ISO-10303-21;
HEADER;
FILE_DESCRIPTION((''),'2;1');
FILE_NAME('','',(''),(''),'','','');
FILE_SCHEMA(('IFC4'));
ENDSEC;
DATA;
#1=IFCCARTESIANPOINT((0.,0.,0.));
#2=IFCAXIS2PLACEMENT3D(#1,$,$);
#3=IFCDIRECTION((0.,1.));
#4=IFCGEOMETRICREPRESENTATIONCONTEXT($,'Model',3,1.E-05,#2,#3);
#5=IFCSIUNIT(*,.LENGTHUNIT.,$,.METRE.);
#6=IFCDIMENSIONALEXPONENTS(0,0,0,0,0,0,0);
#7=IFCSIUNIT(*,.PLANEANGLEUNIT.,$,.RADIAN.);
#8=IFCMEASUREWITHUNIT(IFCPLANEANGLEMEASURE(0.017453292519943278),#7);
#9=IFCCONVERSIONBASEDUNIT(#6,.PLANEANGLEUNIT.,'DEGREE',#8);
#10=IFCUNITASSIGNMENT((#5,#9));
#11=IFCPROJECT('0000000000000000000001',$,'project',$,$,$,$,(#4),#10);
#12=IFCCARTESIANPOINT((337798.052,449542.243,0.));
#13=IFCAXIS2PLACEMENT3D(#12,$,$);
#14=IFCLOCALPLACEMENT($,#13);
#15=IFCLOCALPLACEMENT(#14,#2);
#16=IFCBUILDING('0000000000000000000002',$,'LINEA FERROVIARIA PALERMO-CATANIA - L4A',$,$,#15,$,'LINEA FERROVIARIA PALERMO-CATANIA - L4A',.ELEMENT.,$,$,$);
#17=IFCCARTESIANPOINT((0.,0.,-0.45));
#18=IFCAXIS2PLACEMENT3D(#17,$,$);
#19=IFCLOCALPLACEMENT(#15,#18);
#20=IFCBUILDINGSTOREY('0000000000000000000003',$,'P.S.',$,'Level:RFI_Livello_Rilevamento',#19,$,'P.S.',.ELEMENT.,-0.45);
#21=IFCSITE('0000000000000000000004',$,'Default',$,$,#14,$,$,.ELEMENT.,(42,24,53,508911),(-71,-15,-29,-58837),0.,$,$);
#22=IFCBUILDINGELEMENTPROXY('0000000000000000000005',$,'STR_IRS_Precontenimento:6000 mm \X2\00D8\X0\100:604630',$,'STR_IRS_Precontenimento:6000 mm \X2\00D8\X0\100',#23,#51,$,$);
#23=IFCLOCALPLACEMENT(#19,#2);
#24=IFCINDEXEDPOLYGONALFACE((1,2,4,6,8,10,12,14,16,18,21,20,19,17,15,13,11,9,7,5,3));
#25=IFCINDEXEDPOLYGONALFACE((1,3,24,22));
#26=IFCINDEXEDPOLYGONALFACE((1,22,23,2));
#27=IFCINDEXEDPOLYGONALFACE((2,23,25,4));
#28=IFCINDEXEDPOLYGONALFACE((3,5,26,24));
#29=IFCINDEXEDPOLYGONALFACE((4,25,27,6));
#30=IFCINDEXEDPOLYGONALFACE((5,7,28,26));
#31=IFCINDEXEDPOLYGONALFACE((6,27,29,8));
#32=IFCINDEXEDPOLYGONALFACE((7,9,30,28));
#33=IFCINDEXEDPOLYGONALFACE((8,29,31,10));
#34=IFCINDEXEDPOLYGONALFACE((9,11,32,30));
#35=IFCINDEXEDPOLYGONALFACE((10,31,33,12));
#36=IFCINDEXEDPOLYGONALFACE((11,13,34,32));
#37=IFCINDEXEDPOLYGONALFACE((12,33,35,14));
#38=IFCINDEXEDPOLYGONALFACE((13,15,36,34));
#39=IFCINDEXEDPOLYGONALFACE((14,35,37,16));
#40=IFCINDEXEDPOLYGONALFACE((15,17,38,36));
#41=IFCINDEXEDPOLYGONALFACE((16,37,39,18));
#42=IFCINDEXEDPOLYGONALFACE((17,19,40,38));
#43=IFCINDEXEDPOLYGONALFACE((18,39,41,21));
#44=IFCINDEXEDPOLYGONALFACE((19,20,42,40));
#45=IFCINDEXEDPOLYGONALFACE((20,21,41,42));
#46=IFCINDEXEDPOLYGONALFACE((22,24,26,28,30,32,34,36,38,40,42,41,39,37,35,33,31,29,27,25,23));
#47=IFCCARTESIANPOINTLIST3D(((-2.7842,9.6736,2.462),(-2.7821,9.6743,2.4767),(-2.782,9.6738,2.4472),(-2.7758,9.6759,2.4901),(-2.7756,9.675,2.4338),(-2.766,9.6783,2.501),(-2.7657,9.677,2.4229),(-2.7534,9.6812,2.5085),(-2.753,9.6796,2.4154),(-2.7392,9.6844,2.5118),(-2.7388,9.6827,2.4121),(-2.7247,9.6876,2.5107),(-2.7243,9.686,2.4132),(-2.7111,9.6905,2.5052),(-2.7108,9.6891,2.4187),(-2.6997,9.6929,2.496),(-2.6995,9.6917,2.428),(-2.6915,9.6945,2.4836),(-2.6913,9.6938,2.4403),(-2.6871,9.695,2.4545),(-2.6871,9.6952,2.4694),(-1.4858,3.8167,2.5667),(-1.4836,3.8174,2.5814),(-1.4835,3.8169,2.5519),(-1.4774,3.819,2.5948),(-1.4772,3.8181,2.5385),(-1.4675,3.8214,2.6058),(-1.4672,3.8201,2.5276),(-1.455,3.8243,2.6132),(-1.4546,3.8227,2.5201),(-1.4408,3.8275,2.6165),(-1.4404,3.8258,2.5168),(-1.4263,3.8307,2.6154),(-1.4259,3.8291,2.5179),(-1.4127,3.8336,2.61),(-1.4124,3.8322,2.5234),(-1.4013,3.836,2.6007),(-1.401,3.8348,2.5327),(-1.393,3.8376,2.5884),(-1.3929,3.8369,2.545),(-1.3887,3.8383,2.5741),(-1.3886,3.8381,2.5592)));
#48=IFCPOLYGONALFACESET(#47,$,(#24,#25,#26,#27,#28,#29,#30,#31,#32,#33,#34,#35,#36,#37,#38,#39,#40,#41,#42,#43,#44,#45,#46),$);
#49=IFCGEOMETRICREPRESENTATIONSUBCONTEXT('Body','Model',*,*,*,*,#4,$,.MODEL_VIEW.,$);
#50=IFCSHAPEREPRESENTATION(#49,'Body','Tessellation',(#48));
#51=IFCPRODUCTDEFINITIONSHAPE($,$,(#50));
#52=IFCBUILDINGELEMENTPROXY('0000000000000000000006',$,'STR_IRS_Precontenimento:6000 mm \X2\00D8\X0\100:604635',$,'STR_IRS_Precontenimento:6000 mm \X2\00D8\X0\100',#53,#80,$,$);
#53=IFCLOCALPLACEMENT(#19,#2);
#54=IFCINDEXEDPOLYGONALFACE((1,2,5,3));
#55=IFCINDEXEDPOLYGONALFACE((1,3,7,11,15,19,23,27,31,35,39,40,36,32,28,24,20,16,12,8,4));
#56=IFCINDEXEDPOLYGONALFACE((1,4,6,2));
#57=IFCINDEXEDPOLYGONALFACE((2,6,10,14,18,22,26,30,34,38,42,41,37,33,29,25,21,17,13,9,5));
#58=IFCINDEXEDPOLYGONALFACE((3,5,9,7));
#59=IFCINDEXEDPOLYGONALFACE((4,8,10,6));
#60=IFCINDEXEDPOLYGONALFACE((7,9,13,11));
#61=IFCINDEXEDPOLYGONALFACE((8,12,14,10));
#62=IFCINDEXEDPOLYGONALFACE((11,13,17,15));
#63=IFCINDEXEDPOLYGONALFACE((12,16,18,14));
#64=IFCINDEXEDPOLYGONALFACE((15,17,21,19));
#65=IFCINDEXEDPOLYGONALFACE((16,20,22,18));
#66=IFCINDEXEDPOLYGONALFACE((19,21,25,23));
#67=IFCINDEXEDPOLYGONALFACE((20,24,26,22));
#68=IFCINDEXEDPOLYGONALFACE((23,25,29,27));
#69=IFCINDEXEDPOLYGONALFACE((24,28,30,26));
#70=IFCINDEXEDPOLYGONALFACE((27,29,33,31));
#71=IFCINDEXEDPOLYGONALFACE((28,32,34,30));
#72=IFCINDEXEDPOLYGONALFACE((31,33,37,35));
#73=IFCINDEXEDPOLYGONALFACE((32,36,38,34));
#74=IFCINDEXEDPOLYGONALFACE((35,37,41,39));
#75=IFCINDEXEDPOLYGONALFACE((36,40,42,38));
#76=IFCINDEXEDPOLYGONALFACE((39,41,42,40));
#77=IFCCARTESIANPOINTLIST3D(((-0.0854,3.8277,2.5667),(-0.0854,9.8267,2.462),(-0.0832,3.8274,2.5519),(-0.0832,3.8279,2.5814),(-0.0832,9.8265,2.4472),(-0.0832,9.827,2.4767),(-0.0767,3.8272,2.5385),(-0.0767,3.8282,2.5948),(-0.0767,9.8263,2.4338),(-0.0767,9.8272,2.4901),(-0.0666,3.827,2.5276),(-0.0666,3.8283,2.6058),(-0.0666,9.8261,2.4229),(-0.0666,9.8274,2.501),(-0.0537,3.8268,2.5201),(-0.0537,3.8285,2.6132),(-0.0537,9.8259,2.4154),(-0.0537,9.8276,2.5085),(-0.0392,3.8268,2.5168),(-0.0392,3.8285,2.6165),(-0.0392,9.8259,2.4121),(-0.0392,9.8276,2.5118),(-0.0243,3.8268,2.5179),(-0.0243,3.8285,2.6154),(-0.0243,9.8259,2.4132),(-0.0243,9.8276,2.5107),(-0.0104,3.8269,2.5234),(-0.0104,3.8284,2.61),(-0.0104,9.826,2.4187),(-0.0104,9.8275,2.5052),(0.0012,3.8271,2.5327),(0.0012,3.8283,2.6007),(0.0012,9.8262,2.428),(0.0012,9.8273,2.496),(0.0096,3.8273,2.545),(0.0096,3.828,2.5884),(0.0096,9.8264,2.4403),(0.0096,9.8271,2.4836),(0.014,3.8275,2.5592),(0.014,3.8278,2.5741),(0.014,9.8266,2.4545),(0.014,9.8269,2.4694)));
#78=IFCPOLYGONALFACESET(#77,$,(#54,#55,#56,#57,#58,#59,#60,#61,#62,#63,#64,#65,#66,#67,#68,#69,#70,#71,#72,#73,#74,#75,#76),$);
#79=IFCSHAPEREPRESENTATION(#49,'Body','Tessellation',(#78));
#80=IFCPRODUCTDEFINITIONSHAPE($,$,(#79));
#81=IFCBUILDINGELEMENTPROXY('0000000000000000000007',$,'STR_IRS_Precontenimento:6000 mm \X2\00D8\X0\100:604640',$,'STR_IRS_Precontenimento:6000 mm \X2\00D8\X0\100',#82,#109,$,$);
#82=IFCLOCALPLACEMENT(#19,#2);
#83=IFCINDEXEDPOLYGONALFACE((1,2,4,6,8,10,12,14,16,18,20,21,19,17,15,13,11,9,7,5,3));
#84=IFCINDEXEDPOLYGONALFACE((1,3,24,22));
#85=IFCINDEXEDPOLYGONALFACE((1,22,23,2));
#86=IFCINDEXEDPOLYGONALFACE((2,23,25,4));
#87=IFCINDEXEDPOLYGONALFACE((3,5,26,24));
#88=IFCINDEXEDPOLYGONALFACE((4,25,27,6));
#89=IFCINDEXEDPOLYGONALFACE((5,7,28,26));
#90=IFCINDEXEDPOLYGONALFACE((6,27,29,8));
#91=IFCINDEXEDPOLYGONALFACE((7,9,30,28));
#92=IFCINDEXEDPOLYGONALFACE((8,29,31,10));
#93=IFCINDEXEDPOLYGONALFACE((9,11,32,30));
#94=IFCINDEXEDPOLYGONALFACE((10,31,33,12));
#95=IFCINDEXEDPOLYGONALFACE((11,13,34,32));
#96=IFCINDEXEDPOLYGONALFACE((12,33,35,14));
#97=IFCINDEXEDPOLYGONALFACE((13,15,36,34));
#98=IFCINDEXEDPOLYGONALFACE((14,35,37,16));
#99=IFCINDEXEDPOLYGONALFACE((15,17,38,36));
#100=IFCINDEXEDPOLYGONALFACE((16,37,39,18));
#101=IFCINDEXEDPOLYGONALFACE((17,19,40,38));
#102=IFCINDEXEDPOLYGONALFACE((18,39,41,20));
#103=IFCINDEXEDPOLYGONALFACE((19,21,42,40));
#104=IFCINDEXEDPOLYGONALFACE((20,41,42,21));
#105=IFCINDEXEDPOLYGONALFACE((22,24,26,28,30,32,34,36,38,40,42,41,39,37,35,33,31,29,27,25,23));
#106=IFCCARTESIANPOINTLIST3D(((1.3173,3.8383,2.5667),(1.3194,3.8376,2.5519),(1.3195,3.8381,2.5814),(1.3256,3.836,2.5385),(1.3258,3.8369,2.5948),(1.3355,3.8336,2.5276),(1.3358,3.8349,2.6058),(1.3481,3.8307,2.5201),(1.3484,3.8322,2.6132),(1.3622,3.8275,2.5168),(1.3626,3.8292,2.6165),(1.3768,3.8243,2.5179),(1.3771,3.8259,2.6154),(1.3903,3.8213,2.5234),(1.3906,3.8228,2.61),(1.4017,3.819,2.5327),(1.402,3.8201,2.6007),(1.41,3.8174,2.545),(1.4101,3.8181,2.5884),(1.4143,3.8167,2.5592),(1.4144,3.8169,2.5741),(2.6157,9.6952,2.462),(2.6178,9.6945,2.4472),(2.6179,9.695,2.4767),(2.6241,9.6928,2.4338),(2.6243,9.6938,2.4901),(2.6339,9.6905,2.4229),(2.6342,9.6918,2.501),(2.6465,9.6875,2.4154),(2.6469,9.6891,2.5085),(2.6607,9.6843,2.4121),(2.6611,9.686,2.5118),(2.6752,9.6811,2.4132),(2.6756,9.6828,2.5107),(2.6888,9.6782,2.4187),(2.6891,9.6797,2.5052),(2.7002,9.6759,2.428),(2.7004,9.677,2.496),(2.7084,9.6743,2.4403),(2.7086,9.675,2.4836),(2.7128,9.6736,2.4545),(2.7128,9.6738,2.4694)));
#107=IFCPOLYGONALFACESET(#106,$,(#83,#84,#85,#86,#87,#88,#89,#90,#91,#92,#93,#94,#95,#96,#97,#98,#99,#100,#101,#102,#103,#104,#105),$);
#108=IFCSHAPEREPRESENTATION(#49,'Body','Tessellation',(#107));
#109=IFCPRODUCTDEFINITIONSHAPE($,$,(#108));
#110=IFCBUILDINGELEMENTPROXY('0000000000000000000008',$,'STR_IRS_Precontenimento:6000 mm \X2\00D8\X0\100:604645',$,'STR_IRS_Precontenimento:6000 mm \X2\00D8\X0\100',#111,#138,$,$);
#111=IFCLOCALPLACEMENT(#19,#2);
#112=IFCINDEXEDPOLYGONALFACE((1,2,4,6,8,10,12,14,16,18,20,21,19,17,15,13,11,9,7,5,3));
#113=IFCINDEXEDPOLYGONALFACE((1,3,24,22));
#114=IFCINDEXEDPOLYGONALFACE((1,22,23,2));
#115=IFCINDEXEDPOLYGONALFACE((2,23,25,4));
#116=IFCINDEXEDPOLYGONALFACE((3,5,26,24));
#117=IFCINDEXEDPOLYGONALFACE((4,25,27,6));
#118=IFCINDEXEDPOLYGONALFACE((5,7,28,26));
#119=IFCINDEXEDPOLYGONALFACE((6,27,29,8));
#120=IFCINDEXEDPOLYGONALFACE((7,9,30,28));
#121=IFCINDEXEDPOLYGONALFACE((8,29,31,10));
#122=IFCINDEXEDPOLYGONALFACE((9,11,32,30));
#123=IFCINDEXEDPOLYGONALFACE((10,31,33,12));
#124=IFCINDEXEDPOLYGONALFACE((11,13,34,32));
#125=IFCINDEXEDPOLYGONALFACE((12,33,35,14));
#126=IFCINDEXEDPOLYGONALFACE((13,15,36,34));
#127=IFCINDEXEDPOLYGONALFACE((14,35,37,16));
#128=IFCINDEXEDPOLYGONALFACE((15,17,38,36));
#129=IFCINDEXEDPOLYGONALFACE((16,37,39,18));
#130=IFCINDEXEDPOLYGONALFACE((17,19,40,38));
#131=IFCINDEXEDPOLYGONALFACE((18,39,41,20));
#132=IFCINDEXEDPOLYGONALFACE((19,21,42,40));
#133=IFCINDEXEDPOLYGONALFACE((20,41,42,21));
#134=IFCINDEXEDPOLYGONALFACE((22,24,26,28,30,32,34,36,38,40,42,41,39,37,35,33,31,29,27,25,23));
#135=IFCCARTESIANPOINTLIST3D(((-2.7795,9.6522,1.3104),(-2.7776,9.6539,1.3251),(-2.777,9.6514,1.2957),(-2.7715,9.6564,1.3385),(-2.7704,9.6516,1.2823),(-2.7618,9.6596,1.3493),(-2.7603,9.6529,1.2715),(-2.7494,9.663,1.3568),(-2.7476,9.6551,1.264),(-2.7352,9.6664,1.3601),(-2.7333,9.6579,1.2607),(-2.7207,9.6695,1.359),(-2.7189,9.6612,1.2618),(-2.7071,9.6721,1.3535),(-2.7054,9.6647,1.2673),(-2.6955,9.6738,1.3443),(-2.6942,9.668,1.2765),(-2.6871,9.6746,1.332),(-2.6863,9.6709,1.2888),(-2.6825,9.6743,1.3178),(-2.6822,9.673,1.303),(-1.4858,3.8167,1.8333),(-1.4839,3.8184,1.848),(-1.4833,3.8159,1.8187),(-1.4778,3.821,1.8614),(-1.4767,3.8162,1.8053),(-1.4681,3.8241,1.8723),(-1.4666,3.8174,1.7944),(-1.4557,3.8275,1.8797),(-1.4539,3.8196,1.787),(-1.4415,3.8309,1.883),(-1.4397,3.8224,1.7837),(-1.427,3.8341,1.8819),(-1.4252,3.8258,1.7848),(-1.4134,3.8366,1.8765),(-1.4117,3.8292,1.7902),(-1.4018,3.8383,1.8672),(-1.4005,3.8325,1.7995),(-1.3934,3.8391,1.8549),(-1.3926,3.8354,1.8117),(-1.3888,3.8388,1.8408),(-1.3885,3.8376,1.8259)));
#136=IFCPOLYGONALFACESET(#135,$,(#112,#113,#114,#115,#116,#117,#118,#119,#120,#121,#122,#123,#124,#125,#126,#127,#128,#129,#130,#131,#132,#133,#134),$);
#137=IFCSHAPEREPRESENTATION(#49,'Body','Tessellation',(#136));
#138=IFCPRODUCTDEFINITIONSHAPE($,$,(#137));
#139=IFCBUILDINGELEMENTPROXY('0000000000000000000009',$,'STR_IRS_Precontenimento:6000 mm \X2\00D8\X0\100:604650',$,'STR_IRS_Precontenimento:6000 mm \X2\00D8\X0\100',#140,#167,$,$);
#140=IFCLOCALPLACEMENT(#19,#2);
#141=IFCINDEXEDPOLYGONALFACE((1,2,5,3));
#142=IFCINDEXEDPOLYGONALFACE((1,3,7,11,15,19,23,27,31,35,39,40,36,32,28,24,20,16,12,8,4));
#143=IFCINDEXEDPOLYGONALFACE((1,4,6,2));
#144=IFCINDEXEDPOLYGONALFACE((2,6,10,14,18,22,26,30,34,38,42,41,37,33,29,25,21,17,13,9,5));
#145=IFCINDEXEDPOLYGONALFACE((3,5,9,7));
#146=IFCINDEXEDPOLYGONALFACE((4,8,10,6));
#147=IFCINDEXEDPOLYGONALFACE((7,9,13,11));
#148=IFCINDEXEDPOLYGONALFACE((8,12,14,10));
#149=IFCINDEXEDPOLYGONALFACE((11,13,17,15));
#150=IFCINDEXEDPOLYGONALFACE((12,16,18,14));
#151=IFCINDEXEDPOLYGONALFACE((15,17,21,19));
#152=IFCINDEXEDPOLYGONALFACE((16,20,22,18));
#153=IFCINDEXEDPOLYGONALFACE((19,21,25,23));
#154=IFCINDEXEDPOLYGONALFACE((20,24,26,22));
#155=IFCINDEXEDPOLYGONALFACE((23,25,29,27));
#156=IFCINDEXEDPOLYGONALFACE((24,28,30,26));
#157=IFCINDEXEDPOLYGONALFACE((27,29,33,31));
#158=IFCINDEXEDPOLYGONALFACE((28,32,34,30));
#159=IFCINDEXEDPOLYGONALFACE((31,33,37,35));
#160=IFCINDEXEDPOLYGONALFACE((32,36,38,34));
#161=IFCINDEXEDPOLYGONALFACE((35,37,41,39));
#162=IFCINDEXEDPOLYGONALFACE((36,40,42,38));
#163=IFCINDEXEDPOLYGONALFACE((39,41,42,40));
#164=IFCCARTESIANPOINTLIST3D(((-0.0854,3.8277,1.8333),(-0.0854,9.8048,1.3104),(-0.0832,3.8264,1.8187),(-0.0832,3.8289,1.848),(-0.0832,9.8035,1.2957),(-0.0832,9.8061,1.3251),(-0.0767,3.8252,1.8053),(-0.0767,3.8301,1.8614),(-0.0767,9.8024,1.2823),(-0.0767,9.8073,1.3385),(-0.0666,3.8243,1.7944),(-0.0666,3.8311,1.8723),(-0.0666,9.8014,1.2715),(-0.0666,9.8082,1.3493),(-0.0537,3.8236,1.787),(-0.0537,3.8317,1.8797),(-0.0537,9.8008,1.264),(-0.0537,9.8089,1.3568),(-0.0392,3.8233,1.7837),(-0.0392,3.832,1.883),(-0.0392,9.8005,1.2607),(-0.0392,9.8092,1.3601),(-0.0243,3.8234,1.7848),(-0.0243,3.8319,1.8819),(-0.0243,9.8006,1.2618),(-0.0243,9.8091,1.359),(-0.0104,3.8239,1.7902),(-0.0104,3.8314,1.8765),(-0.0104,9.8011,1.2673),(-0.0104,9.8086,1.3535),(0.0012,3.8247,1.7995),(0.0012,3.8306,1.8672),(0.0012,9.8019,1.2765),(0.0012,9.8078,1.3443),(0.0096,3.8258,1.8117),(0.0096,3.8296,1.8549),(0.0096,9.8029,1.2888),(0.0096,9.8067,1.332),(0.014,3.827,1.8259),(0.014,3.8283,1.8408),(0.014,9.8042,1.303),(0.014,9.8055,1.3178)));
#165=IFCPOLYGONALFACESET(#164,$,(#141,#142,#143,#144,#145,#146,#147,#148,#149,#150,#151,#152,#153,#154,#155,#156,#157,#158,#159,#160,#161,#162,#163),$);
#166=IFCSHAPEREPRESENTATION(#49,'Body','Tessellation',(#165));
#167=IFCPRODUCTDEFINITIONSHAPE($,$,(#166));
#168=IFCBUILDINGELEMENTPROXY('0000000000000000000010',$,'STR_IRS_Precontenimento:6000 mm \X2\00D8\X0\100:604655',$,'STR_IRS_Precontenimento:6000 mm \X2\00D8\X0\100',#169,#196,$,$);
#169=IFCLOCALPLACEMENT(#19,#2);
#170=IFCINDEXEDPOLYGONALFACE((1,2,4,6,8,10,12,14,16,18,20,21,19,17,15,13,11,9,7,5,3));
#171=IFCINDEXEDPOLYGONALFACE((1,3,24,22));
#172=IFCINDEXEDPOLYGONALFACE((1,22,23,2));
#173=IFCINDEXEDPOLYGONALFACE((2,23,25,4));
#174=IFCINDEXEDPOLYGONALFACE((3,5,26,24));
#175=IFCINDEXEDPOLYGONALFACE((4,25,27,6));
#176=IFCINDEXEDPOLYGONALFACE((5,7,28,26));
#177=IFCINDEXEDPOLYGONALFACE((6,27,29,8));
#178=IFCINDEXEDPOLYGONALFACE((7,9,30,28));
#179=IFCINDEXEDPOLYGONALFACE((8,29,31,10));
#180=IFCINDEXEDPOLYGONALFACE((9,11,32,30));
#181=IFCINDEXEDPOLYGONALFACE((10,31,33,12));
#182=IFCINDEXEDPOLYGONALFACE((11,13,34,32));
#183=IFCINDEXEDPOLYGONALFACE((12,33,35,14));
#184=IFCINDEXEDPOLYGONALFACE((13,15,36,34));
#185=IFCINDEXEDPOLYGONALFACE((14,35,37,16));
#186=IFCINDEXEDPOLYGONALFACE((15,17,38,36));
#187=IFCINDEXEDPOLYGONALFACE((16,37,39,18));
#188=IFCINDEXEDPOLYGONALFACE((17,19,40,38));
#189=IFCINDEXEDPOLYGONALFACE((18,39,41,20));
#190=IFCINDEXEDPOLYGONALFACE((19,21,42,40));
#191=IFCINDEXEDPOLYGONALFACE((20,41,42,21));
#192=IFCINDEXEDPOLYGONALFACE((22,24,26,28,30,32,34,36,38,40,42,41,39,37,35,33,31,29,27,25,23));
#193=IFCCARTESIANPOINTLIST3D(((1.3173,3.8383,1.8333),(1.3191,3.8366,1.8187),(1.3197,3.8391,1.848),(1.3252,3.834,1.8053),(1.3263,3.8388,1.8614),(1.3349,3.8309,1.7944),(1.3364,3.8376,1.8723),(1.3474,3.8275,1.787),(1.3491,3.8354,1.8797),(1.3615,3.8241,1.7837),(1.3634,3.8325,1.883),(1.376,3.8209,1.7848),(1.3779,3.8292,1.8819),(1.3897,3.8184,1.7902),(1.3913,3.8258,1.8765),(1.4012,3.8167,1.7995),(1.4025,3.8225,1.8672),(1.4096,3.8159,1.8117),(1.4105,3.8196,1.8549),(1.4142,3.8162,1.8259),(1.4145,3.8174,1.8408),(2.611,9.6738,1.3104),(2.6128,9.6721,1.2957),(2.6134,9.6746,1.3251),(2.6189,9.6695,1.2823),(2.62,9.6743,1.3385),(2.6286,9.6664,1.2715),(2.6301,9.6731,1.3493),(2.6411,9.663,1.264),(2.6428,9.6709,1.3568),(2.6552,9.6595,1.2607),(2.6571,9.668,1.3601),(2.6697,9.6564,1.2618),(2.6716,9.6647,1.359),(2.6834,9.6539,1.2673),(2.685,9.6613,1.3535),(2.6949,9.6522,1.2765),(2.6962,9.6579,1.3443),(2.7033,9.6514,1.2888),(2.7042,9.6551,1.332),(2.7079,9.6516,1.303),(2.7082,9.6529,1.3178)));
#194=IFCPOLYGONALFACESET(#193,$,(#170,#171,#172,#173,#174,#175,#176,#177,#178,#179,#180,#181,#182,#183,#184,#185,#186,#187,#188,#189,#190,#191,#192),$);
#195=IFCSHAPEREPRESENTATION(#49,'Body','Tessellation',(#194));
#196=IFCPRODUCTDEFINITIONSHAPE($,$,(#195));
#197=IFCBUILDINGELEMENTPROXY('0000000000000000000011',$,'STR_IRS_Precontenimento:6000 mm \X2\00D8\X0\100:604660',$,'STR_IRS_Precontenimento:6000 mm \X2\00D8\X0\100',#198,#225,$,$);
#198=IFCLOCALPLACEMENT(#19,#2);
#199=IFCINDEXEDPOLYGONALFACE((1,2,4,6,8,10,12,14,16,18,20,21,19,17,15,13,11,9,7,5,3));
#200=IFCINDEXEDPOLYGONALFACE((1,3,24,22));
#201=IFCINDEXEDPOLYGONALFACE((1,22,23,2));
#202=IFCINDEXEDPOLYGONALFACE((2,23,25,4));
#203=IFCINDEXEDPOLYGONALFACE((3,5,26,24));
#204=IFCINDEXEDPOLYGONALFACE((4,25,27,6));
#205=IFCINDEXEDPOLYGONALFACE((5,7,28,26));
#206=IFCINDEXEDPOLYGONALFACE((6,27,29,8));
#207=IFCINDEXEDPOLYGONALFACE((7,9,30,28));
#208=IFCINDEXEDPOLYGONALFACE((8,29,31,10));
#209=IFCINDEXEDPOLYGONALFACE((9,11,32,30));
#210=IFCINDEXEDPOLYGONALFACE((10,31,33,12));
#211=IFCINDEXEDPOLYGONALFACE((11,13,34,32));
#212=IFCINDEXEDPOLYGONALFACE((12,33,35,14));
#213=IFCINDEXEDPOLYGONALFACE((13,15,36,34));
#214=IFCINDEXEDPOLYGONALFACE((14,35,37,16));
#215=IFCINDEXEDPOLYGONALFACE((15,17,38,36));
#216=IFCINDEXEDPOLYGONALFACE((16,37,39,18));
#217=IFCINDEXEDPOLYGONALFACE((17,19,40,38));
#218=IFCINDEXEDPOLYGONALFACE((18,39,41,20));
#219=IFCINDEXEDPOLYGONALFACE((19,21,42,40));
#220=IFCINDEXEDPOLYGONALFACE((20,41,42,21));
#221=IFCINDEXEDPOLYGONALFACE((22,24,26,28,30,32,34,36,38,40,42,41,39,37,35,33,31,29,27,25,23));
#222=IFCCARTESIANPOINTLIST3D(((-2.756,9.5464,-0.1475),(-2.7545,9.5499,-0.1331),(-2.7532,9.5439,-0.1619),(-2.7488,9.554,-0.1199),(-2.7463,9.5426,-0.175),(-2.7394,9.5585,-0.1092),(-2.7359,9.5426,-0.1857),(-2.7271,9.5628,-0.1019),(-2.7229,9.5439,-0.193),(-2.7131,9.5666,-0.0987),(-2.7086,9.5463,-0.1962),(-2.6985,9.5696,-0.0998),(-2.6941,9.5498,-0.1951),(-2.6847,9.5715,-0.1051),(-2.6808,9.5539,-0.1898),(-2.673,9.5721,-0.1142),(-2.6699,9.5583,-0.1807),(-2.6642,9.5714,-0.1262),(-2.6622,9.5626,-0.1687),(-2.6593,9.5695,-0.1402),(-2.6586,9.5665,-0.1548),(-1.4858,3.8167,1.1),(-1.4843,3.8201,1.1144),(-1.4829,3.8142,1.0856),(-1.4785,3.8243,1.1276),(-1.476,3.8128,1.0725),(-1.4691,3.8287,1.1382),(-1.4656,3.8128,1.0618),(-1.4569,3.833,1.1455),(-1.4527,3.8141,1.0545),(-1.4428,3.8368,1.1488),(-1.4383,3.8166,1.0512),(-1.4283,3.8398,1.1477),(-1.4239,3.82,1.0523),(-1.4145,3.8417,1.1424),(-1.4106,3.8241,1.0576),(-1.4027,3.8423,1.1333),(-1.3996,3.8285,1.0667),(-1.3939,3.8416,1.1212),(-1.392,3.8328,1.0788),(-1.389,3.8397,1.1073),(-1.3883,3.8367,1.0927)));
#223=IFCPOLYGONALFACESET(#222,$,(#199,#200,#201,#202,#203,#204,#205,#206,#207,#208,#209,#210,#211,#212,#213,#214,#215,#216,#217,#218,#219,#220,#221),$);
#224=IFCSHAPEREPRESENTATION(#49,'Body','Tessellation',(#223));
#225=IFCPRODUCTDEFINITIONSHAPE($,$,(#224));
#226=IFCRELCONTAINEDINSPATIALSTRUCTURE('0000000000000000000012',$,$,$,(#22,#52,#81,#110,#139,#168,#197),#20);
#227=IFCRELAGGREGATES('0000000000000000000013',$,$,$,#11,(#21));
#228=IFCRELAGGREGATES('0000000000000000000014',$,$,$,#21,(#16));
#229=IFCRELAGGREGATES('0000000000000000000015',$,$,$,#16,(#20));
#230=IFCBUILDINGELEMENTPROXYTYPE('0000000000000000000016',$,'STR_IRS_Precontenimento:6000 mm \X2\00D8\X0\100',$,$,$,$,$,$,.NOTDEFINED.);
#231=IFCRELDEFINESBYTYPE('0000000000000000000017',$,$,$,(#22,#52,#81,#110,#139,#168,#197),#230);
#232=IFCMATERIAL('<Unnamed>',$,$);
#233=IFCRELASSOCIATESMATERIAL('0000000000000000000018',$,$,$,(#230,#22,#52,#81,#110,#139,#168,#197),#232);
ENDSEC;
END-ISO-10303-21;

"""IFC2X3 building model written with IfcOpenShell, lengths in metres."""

from ifc_helpers import new_model, entity, si_unit, converted_unit, direction, frame, frame_2d, origin, place, context, subcontext, project, spatial, circle, extrude, source, transform, mapped, material, type_object, type_shapes, element, save


model = new_model("IFC2X3")

# Units and contexts
model_context = context("Model", 3, precision=1e-05, world=origin(), true_north=direction((0.0, 1.0)))
body_context = subcontext(model_context, "Body", "Model", "MODEL_VIEW")
ifc_project = project(units=[si_unit("LENGTHUNIT", "METRE"), converted_unit("PLANEANGLEUNIT", "DEGREE", entity("IfcPlaneAngleMeasure", 0.017453292519943278), si_unit("PLANEANGLEUNIT", "RADIAN"), dimensions=[0, 0, 0, 0, 0, 0, 0])], contexts=[model_context])

# Site, building, storey
site_placement = place(None, frame((337798.052, 449542.243, 0.0)))
site = spatial("IfcSite", under=ifc_project, at=site_placement, Name="Default", CompositionType="ELEMENT", RefLatitude=(42, 24, 53, 508911), RefLongitude=(-71, -15, -29, -58837), RefElevation=0.0)
building_placement = place(site_placement, origin())
building = spatial("IfcBuilding", under=site, at=building_placement, Name="LINEA FERROVIARIA PALERMO-CATANIA - L4A", LongName="LINEA FERROVIARIA PALERMO-CATANIA - L4A", CompositionType="ELEMENT")
storey_placement = place(building_placement, frame((0.0, 0.0, -0.45)))
storey = spatial("IfcBuildingStorey", under=building, at=storey_placement, Name="P.S.", ObjectType="Level:RFI_Livello_Rilevamento", LongName="P.S.", CompositionType="ELEMENT", Elevation=-0.45)

# Building element proxies
ifc_material = material(Name="<Unnamed>")
building_element_proxy_type = type_object("IfcBuildingElementProxyType", Name="STR_IRS_Precontenimento:6000 mm Ø100", PredefinedType="NOTDEFINED", material=ifc_material)
shared_shape = source(origin(), body_context, "Body", "SweptSolid", [
    extrude(circle(Radius=0.05, at=frame_2d((0.0, 0.0), x_axis=(1.0, 0.0))), frame((0.0, 0.0, -6.0)), (0.0, 0.0, 1.0), 6.0),
])
type_shapes(building_element_proxy_type, [shared_shape])
for number, where, z_axis, x_axis, name in (
    (1, (-1.4369, 3.8275, 2.5667), (0.216407, -0.976147, 0.017452), (-0.976296, -0.21644, 0.0), "STR_IRS_Precontenimento:6000 mm Ø100:604630"),
    (2, (-0.0354, 3.8277, 2.5667), (0.0, -0.999848, 0.017452), (-1.0, 0.0, 0.0), "STR_IRS_Precontenimento:6000 mm Ø100:604635"),
    (3, (1.3661, 3.8275, 2.5667), (-0.216407, -0.976147, 0.017452), (-0.976296, 0.21644, 0.0), "STR_IRS_Precontenimento:6000 mm Ø100:604640"),
    (4, (-1.4369, 3.8275, 1.8333), (0.215616, -0.972581, 0.087156), (-0.976296, -0.21644, 0.0), "STR_IRS_Precontenimento:6000 mm Ø100:604645"),
    (5, (-0.0354, 3.8277, 1.8333), (0.0, -0.996195, 0.087156), (-1.0, 0.0, 0.0), "STR_IRS_Precontenimento:6000 mm Ø100:604650"),
    (6, (1.3661, 3.8275, 1.8333), (-0.215616, -0.972581, 0.087156), (-0.976296, 0.21644, 0.0), "STR_IRS_Precontenimento:6000 mm Ø100:604655"),
    (7, (-1.4369, 3.8275, 1.1), (0.21171, -0.954962, 0.207912), (-0.976296, -0.21644, 0.0), "STR_IRS_Precontenimento:6000 mm Ø100:604660"),
):
    element("IfcBuildingElementProxy", number, at=place(storey_placement, frame(where, z_axis=z_axis, x_axis=x_axis)), inside=storey, type_object=building_element_proxy_type, material=ifc_material, Name=name, ObjectType="STR_IRS_Precontenimento:6000 mm Ø100", context=body_context, shape_type="MappedRepresentation", body=[
        mapped(shared_shape, transform((0.0, 0.0, 0.0), scale=1.0)),
    ])

save(model, "model.ifc")
